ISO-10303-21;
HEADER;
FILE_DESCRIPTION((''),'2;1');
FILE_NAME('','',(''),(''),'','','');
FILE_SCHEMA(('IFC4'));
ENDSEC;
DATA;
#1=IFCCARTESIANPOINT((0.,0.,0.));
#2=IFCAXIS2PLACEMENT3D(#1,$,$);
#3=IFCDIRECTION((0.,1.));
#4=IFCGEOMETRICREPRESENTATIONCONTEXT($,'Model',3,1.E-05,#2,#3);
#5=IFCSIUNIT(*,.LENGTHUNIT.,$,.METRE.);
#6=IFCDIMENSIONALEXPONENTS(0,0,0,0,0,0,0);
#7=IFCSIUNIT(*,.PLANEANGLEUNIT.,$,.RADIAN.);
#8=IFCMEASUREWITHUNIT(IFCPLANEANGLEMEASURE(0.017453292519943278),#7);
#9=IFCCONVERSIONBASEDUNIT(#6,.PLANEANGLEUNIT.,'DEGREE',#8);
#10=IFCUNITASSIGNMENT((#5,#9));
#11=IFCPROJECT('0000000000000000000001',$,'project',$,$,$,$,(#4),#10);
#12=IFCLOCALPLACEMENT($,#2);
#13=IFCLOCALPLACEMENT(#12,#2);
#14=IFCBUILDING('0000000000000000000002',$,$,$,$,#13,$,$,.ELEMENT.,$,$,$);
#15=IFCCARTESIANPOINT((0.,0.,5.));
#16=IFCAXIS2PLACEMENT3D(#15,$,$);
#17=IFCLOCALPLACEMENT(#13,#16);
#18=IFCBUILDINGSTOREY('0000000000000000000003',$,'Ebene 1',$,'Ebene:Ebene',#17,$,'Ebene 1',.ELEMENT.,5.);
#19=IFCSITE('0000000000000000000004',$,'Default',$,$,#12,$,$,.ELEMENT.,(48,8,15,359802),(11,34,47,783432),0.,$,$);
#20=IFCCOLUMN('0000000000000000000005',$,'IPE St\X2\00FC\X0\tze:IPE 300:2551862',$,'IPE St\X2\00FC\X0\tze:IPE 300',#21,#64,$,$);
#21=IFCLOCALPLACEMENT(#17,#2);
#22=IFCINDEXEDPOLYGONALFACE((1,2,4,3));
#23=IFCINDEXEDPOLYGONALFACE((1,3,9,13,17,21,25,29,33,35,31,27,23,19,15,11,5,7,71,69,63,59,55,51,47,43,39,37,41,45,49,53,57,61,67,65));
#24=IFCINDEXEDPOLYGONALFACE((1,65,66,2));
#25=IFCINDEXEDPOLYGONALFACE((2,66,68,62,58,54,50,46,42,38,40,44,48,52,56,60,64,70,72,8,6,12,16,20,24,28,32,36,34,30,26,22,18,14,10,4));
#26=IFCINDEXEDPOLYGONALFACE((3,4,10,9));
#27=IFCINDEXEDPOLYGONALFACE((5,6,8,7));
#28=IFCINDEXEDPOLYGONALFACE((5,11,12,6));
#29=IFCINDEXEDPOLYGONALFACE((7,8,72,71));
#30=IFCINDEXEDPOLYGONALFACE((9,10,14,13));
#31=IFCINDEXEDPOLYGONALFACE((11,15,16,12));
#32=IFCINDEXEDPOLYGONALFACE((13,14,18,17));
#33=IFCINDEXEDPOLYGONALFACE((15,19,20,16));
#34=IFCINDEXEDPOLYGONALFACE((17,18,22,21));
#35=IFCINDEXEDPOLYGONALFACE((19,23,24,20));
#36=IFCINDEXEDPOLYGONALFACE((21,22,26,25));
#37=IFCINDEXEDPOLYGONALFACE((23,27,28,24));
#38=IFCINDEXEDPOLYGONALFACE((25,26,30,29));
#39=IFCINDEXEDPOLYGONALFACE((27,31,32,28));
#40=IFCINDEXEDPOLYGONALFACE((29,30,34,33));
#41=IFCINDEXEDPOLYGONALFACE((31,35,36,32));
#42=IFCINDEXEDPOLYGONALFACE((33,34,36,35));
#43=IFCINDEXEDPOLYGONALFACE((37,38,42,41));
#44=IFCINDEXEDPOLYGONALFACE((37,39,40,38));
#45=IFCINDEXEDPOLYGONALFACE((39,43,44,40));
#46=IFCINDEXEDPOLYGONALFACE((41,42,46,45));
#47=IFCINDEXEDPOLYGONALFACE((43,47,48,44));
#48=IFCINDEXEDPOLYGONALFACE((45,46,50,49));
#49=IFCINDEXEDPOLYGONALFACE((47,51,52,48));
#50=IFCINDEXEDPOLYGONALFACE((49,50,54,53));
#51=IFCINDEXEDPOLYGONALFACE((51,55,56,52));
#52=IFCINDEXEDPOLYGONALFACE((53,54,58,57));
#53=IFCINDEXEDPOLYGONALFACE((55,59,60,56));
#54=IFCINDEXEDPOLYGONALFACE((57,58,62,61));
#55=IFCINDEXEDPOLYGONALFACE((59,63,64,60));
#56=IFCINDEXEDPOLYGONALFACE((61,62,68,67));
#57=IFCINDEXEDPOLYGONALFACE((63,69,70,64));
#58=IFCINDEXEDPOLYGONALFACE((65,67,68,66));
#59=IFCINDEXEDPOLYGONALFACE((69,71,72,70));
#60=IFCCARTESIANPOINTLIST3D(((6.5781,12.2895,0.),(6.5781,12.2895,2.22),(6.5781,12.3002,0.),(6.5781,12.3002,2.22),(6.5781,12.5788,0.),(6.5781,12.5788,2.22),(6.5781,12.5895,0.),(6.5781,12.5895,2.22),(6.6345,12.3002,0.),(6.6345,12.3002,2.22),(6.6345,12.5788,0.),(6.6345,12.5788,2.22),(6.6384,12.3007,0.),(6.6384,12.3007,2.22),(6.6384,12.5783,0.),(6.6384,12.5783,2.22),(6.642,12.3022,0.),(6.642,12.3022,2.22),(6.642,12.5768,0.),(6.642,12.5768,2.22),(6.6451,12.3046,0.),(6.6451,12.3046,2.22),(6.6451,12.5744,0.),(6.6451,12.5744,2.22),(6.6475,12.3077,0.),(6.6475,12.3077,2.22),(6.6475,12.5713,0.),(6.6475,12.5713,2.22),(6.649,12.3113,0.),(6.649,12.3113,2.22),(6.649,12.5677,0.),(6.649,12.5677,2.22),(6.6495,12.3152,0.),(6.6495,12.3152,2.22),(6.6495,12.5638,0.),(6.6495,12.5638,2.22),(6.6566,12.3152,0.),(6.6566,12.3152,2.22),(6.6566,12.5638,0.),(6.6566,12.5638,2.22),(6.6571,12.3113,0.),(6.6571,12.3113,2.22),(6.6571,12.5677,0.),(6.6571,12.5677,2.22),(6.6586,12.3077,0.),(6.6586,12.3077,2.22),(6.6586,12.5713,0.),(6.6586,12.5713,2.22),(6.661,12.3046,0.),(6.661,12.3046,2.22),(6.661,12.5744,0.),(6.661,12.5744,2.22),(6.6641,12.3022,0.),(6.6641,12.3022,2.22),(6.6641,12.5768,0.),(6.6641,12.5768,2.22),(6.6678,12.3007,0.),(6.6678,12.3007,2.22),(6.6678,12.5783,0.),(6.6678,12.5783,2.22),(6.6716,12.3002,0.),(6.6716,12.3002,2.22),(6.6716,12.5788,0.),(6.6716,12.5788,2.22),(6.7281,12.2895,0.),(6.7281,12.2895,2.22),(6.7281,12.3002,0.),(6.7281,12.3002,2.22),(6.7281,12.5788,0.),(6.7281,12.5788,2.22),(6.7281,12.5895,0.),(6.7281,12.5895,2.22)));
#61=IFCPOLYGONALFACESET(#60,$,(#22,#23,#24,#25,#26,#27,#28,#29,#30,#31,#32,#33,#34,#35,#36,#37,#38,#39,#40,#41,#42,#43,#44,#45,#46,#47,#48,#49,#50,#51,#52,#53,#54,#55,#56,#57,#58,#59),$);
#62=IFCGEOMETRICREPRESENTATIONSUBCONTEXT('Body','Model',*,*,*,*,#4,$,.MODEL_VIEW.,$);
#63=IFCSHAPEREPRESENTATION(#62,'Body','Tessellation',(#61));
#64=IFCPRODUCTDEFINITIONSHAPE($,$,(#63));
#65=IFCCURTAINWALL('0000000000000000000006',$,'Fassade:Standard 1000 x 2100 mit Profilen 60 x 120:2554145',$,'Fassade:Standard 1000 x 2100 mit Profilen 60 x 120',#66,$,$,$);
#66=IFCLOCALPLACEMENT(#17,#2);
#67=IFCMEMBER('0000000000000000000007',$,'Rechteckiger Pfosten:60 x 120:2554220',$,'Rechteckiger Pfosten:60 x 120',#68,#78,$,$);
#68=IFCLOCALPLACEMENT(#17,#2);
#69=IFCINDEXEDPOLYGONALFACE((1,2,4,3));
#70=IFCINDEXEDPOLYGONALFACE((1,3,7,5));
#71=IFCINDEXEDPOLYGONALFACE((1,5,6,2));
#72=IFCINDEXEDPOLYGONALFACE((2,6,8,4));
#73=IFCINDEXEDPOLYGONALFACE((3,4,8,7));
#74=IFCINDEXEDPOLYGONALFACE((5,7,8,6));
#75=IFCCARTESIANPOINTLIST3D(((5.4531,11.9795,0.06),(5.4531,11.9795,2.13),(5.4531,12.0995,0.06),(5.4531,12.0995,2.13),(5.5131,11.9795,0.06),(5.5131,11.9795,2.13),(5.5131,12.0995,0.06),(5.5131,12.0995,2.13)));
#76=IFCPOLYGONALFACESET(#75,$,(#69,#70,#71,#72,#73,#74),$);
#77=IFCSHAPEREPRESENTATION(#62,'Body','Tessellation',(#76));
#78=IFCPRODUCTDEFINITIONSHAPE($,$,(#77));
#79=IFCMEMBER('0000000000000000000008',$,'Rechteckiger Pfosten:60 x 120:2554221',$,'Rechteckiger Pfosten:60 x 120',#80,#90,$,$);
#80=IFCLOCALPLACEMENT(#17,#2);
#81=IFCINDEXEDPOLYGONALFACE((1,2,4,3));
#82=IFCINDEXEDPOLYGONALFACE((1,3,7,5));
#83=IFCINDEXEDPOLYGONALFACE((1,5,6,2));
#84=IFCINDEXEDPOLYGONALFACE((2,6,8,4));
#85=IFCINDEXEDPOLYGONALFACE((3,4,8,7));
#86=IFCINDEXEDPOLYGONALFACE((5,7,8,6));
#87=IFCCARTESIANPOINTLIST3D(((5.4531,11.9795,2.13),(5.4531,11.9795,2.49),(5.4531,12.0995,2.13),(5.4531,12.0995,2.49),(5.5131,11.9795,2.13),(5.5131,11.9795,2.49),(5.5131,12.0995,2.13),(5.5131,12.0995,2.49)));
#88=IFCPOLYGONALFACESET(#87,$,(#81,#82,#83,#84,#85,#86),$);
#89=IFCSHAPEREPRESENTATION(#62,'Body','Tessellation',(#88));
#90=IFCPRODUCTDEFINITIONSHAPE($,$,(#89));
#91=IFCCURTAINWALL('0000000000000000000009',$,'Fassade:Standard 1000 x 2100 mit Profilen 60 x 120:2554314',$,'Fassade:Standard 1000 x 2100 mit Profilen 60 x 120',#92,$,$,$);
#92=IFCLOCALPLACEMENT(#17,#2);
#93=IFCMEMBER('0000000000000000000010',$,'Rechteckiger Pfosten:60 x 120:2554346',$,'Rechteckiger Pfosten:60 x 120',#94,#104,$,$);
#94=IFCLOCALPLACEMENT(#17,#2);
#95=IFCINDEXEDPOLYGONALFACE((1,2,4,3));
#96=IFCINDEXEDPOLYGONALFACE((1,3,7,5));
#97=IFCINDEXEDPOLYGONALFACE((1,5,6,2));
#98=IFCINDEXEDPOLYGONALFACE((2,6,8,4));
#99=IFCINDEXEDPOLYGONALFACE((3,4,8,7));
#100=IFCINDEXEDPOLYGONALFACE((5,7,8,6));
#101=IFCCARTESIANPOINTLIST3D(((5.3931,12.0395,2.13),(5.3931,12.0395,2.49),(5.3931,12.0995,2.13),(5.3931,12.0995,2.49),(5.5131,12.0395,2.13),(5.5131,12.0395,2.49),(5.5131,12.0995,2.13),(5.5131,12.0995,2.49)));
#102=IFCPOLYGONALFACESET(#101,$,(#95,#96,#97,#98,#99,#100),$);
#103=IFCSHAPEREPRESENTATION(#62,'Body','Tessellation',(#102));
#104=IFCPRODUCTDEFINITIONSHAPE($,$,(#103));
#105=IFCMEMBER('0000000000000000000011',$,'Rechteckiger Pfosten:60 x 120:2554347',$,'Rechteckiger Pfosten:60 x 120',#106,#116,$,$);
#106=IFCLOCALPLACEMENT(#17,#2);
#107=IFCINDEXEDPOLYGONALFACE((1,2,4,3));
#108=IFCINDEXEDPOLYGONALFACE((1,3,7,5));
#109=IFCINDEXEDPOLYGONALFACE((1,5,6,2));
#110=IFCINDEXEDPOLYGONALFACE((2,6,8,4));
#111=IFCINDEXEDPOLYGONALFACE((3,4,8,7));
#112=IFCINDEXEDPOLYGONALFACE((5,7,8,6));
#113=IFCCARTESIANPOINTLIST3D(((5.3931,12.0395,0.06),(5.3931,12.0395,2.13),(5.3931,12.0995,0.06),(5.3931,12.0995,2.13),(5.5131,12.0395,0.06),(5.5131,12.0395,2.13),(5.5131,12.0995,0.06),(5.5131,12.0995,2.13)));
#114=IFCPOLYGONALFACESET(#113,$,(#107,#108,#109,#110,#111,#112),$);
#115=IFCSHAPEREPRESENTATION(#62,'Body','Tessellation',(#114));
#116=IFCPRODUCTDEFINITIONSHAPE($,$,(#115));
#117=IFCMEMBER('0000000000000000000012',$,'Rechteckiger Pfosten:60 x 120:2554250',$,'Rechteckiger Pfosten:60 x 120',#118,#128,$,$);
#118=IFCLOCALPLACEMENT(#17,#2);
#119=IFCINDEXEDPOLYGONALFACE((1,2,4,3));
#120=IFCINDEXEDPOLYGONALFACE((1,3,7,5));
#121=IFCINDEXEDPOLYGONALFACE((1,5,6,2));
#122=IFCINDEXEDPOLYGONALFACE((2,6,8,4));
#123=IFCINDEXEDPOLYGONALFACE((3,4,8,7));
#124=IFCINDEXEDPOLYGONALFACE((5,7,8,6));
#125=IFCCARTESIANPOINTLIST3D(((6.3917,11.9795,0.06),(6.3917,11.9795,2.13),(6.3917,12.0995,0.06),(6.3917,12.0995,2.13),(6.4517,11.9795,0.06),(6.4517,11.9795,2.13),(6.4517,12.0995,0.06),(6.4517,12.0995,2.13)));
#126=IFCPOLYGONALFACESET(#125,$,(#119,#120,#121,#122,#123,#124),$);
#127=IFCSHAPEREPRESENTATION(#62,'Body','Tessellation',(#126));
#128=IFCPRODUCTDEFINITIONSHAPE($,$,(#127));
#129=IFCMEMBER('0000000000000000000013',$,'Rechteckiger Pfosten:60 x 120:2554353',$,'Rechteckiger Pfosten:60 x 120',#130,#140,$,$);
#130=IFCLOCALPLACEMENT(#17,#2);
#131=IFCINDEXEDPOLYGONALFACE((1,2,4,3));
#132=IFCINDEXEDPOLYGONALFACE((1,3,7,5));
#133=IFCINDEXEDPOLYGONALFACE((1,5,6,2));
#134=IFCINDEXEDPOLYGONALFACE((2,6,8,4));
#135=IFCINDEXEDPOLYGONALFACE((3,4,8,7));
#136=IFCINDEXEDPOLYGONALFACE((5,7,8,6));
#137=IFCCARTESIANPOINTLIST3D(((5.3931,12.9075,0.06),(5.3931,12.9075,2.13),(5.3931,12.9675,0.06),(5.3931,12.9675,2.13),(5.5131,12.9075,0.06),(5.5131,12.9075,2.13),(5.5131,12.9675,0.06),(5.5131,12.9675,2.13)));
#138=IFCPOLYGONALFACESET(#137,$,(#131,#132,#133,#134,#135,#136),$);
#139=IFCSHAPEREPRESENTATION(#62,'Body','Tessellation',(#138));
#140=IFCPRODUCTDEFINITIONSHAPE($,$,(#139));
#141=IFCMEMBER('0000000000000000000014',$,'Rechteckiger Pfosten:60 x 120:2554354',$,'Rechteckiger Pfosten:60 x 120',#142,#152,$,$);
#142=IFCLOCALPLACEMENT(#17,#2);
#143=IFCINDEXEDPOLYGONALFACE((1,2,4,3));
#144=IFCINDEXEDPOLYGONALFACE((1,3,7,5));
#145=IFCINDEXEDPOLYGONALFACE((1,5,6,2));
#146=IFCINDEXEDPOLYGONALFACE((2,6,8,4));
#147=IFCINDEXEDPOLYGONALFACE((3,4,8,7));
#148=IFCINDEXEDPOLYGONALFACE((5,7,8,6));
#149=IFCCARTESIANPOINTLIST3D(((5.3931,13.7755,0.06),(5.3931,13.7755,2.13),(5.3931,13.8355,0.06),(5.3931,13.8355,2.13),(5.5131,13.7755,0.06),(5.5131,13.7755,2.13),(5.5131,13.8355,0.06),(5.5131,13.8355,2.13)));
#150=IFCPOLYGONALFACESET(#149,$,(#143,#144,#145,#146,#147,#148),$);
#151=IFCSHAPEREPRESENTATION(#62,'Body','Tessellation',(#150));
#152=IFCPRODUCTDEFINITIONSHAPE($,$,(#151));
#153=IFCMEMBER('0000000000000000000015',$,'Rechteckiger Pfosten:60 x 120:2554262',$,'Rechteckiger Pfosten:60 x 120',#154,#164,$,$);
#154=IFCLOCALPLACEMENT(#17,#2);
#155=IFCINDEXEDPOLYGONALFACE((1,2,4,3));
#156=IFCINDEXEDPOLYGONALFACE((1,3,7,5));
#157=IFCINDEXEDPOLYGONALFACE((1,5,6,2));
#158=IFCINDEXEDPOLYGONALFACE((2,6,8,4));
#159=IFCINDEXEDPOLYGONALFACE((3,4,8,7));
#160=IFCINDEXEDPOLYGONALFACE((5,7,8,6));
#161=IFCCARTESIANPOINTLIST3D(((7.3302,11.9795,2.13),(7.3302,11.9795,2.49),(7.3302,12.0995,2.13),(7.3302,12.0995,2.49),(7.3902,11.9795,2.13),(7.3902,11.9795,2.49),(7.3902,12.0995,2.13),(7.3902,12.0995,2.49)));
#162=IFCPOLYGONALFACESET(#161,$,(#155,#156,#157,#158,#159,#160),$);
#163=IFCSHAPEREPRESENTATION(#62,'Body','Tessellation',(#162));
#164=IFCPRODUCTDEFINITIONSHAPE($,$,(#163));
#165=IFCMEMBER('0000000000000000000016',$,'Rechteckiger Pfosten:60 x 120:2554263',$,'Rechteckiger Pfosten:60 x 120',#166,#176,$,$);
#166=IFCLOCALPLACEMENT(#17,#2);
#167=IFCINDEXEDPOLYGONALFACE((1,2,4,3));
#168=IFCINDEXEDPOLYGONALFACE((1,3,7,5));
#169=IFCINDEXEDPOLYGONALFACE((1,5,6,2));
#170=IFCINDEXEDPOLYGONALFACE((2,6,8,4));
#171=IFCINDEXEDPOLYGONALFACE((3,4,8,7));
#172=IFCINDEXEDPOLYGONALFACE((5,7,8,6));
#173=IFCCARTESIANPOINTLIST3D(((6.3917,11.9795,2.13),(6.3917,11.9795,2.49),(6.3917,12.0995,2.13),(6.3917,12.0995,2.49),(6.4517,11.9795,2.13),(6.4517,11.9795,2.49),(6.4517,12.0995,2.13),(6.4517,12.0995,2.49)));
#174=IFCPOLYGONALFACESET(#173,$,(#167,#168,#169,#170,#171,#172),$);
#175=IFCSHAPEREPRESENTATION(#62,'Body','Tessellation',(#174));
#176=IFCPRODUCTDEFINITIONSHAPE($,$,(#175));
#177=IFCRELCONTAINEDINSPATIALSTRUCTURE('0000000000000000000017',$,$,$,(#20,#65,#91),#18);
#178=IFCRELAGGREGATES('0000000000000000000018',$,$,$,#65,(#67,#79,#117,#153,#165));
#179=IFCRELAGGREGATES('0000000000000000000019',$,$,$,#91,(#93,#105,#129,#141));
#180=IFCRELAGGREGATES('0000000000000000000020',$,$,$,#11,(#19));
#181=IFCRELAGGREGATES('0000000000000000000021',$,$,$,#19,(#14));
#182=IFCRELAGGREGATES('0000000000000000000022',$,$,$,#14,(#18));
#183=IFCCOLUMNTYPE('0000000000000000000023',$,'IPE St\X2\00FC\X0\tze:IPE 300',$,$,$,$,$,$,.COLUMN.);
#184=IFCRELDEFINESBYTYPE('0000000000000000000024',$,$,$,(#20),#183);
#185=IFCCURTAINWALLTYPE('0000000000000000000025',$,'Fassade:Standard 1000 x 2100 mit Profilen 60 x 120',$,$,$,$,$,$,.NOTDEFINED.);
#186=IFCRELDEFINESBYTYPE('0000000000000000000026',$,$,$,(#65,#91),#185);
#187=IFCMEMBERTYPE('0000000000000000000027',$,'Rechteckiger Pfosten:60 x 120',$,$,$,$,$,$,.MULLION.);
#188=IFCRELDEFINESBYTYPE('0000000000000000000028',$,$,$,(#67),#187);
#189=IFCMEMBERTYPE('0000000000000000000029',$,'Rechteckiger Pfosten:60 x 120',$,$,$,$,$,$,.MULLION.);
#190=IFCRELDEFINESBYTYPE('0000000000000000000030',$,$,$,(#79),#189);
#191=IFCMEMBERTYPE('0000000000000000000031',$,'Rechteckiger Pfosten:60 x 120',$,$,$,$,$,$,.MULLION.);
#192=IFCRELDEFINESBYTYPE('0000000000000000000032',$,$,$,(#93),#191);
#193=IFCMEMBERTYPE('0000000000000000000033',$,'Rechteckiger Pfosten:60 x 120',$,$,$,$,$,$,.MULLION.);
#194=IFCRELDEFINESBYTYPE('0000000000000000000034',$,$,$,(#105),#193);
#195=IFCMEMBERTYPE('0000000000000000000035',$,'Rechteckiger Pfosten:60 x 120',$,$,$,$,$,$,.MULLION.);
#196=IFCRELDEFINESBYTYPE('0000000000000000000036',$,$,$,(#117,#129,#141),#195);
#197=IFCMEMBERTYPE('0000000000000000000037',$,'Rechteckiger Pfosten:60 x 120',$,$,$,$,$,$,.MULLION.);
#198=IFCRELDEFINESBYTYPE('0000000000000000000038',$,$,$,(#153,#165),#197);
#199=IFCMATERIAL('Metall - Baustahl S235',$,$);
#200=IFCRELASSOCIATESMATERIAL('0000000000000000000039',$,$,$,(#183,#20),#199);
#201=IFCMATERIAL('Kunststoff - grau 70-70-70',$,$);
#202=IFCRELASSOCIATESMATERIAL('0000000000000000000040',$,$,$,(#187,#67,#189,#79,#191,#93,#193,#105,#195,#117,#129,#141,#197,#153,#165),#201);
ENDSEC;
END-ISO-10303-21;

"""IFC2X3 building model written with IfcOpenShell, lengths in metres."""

from ifc_helpers import new_model, entity, si_unit, converted_unit, direction, frame, frame_2d, origin, origin_2d_with_axis, place, context, subcontext, project, spatial, rectangle, i_section, extrude, source, transform, mapped, material, type_object, type_shapes, element, aggregate, save


model = new_model("IFC2X3")

# Units and contexts
model_context = context("Model", 3, precision=1e-05, world=origin(), true_north=direction((0.0, 1.0)))
body_context = subcontext(model_context, "Body", "Model", "MODEL_VIEW")
ifc_project = project(units=[si_unit("LENGTHUNIT", "METRE"), converted_unit("PLANEANGLEUNIT", "DEGREE", entity("IfcPlaneAngleMeasure", 0.017453292519943278), si_unit("PLANEANGLEUNIT", "RADIAN"), dimensions=[0, 0, 0, 0, 0, 0, 0])], contexts=[model_context])

# Site, building, storey
site_placement = place(None, origin())
site = spatial("IfcSite", under=ifc_project, at=site_placement, Name="Default", CompositionType="ELEMENT", RefLatitude=(48, 8, 15, 359802), RefLongitude=(11, 34, 47, 783432), RefElevation=0.0)
building_placement = place(site_placement, origin())
building = spatial("IfcBuilding", under=site, at=building_placement, CompositionType="ELEMENT")
storey_placement = place(building_placement, frame((0.0, 0.0, 5.0)))
storey = spatial("IfcBuildingStorey", under=building, at=storey_placement, Name="Ebene 1", ObjectType="Ebene:Ebene", LongName="Ebene 1", CompositionType="ELEMENT", Elevation=5.0)

# Column
ifc_material_1 = material(Name="Metall - Baustahl S235")
column_type = type_object("IfcColumnType", Name="IPE Stütze:IPE 300", PredefinedType="COLUMN", material=ifc_material_1)
shared_shape_1 = source(origin(), body_context, "Body", "SweptSolid", [
    extrude(i_section(OverallWidth=0.15, OverallDepth=0.3, WebThickness=0.0071, FlangeThickness=0.0107, FilletRadius=0.015, at=origin_2d_with_axis()), frame((0.0, 0.0, 5.0), z_axis=(0.0, 0.0, 1.0), x_axis=(-1.0, 0.0, 0.0)), (0.0, 0.0, 1.0), 2.22),
])
type_shapes(column_type, [shared_shape_1])
column_placement = place(storey_placement, frame((6.6531, 12.4395, -5.0)))
element("IfcColumn", 1, at=column_placement, inside=storey, type_object=column_type, material=ifc_material_1, Name="IPE Stütze:IPE 300:2551862", ObjectType="IPE Stütze:IPE 300", context=body_context, shape_type="MappedRepresentation", body=[
    mapped(shared_shape_1, transform((0.0, 0.0, 0.0), scale=1.0)),
])

# Curtain walls, members
curtain_wall_type = type_object("IfcCurtainWallType", Name="Fassade:Standard 1000 x 2100 mit Profilen 60 x 120", PredefinedType="NOTDEFINED")
curtain_wall_1_placement = place(storey_placement, frame((0.0, 0.0, -5.0)))
curtain_wall_1 = element("IfcCurtainWall", 2, at=curtain_wall_1_placement, inside=storey, type_object=curtain_wall_type, Name="Fassade:Standard 1000 x 2100 mit Profilen 60 x 120:2554145", ObjectType="Fassade:Standard 1000 x 2100 mit Profilen 60 x 120")
ifc_material_2 = material(Name="Kunststoff - grau 70-70-70")
member_type_1 = type_object("IfcMemberType", Name="Rechteckiger Pfosten:60 x 120", PredefinedType="MULLION", material=ifc_material_2)
shared_shape_2 = source(origin(), body_context, "Body", "SweptSolid", [
    extrude(rectangle(XDim=0.06, YDim=0.12, at=origin_2d_with_axis()), frame((-0.03, 0.0, -2.07), z_axis=(0.0, 0.0, 1.0), x_axis=(-1.0, 0.0, 0.0)), (0.0, 0.0, 1.0), 2.07),
])
type_shapes(member_type_1, [shared_shape_2])
member_1_placement = place(curtain_wall_1_placement, frame((5.4531, 12.0395, 5.06), z_axis=(0.0, 0.0, -1.0), x_axis=(-1.0, 0.0, 0.0)))
member_1 = element("IfcMember", 3, at=member_1_placement, type_object=member_type_1, material=ifc_material_2, Name="Rechteckiger Pfosten:60 x 120:2554220", ObjectType="Rechteckiger Pfosten:60 x 120", context=body_context, shape_type="MappedRepresentation", body=[
    mapped(shared_shape_2, transform((0.0, 0.0, 0.0), scale=1.0)),
])
member_type_2 = type_object("IfcMemberType", Name="Rechteckiger Pfosten:60 x 120", PredefinedType="MULLION", material=ifc_material_2)
shared_shape_3 = source(origin(), body_context, "Body", "SweptSolid", [
    extrude(rectangle(XDim=0.06, YDim=0.12, at=origin_2d_with_axis()), frame((-0.03, 0.0, -0.36), z_axis=(0.0, 0.0, 1.0), x_axis=(-1.0, 0.0, 0.0)), (0.0, 0.0, 1.0), 0.36),
])
type_shapes(member_type_2, [shared_shape_3])
member_2_placement = place(curtain_wall_1_placement, frame((5.4531, 12.0395, 7.13), z_axis=(0.0, 0.0, -1.0), x_axis=(-1.0, 0.0, 0.0)))
member_2 = element("IfcMember", 4, at=member_2_placement, type_object=member_type_2, material=ifc_material_2, Name="Rechteckiger Pfosten:60 x 120:2554221", ObjectType="Rechteckiger Pfosten:60 x 120", context=body_context, shape_type="MappedRepresentation", body=[
    mapped(shared_shape_3, transform((0.0, 0.0, 0.0), scale=1.0)),
])
curtain_wall_2_placement = place(storey_placement, frame((0.0, 0.0, -5.0)))
curtain_wall_2 = element("IfcCurtainWall", 5, at=curtain_wall_2_placement, inside=storey, type_object=curtain_wall_type, Name="Fassade:Standard 1000 x 2100 mit Profilen 60 x 120:2554314", ObjectType="Fassade:Standard 1000 x 2100 mit Profilen 60 x 120")
member_type_3 = type_object("IfcMemberType", Name="Rechteckiger Pfosten:60 x 120", PredefinedType="MULLION", material=ifc_material_2)
shared_shape_4 = source(origin(), body_context, "Body", "SweptSolid", [
    extrude(rectangle(XDim=0.06, YDim=0.12, at=origin_2d_with_axis()), frame((-0.03, 0.0, -0.36), z_axis=(0.0, 0.0, 1.0), x_axis=(-1.0, 0.0, 0.0)), (0.0, 0.0, 1.0), 0.36),
])
type_shapes(member_type_3, [shared_shape_4])
member_3_placement = place(curtain_wall_2_placement, frame((5.4531, 12.0395, 7.49), z_axis=(0.0, 0.0, 1.0), x_axis=(0.0, -1.0, 0.0)))
member_3 = element("IfcMember", 6, at=member_3_placement, type_object=member_type_3, material=ifc_material_2, Name="Rechteckiger Pfosten:60 x 120:2554346", ObjectType="Rechteckiger Pfosten:60 x 120", context=body_context, shape_type="MappedRepresentation", body=[
    mapped(shared_shape_4, transform((0.0, 0.0, 0.0), scale=1.0)),
])
member_type_4 = type_object("IfcMemberType", Name="Rechteckiger Pfosten:60 x 120", PredefinedType="MULLION", material=ifc_material_2)
shared_shape_5 = source(origin(), body_context, "Body", "SweptSolid", [
    extrude(rectangle(XDim=0.06, YDim=0.12, at=origin_2d_with_axis()), frame((-0.03, 0.0, -2.07), z_axis=(0.0, 0.0, 1.0), x_axis=(-1.0, 0.0, 0.0)), (0.0, 0.0, 1.0), 2.07),
])
type_shapes(member_type_4, [shared_shape_5])
member_4_placement = place(curtain_wall_2_placement, frame((5.4531, 12.0395, 7.13), z_axis=(0.0, 0.0, 1.0), x_axis=(0.0, -1.0, 0.0)))
member_4 = element("IfcMember", 7, at=member_4_placement, type_object=member_type_4, material=ifc_material_2, Name="Rechteckiger Pfosten:60 x 120:2554347", ObjectType="Rechteckiger Pfosten:60 x 120", context=body_context, shape_type="MappedRepresentation", body=[
    mapped(shared_shape_5, transform((0.0, 0.0, 0.0), scale=1.0)),
])

# Members
member_type_5 = type_object("IfcMemberType", Name="Rechteckiger Pfosten:60 x 120", PredefinedType="MULLION", material=ifc_material_2)
shared_shape_6 = source(origin(), body_context, "Body", "SweptSolid", [
    extrude(rectangle(XDim=0.06, YDim=0.12, at=origin_2d_with_axis()), frame((0.0, 0.0, -2.07), z_axis=(0.0, 0.0, 1.0), x_axis=(-1.0, 0.0, 0.0)), (0.0, 0.0, 1.0), 2.07),
])
type_shapes(member_type_5, [shared_shape_6])
member_5_placement = place(curtain_wall_1_placement, frame((6.4217, 12.0395, 5.06), z_axis=(0.0, 0.0, -1.0), x_axis=(-1.0, 0.0, 0.0)))
member_5 = element("IfcMember", 8, at=member_5_placement, type_object=member_type_5, material=ifc_material_2, Name="Rechteckiger Pfosten:60 x 120:2554250", ObjectType="Rechteckiger Pfosten:60 x 120", context=body_context, shape_type="MappedRepresentation", body=[
    mapped(shared_shape_6, transform((0.0, 0.0, 0.0), scale=1.0)),
])
member_6_placement = place(curtain_wall_2_placement, frame((5.4531, 12.9375, 5.06), z_axis=(0.0, 0.0, -1.0), x_axis=(0.0, 1.0, 0.0)))
member_6 = element("IfcMember", 9, at=member_6_placement, type_object=member_type_5, material=ifc_material_2, Name="Rechteckiger Pfosten:60 x 120:2554353", ObjectType="Rechteckiger Pfosten:60 x 120", context=body_context, shape_type="MappedRepresentation", body=[
    mapped(shared_shape_6, transform((0.0, 0.0, 0.0), scale=1.0)),
])
member_7_placement = place(curtain_wall_2_placement, frame((5.4531, 13.8055, 5.06), z_axis=(0.0, 0.0, -1.0), x_axis=(0.0, 1.0, 0.0)))
member_7 = element("IfcMember", 10, at=member_7_placement, type_object=member_type_5, material=ifc_material_2, Name="Rechteckiger Pfosten:60 x 120:2554354", ObjectType="Rechteckiger Pfosten:60 x 120", context=body_context, shape_type="MappedRepresentation", body=[
    mapped(shared_shape_6, transform((0.0, 0.0, 0.0), scale=1.0)),
])
member_type_6 = type_object("IfcMemberType", Name="Rechteckiger Pfosten:60 x 120", PredefinedType="MULLION", material=ifc_material_2)
shared_shape_7 = source(origin(), body_context, "Body", "SweptSolid", [
    extrude(rectangle(XDim=0.06, YDim=0.12, at=frame_2d((0.0, 0.0), x_axis=(1.0, 0.0))), frame((0.0, 0.0, -0.36), z_axis=(0.0, 0.0, 1.0), x_axis=(-1.0, 0.0, 0.0)), (0.0, 0.0, 1.0), 0.36),
])
type_shapes(member_type_6, [shared_shape_7])
member_8_placement = place(curtain_wall_1_placement, frame((7.3602, 12.0395, 7.13), z_axis=(0.0, 0.0, -1.0), x_axis=(-1.0, 0.0, 0.0)))
member_8 = element("IfcMember", 11, at=member_8_placement, type_object=member_type_6, material=ifc_material_2, Name="Rechteckiger Pfosten:60 x 120:2554262", ObjectType="Rechteckiger Pfosten:60 x 120", context=body_context, shape_type="MappedRepresentation", body=[
    mapped(shared_shape_7, transform((0.0, 0.0, 0.0), scale=1.0)),
])
member_9_placement = place(curtain_wall_1_placement, frame((6.4217, 12.0395, 7.13), z_axis=(0.0, 0.0, -1.0), x_axis=(-1.0, 0.0, 0.0)))
member_9 = element("IfcMember", 12, at=member_9_placement, type_object=member_type_6, material=ifc_material_2, Name="Rechteckiger Pfosten:60 x 120:2554263", ObjectType="Rechteckiger Pfosten:60 x 120", context=body_context, shape_type="MappedRepresentation", body=[
    mapped(shared_shape_7, transform((0.0, 0.0, 0.0), scale=1.0)),
])

aggregate(curtain_wall_1, [member_1, member_2, member_5, member_8, member_9])
aggregate(curtain_wall_2, [member_3, member_4, member_6, member_7])

save(model, "model.ifc")
